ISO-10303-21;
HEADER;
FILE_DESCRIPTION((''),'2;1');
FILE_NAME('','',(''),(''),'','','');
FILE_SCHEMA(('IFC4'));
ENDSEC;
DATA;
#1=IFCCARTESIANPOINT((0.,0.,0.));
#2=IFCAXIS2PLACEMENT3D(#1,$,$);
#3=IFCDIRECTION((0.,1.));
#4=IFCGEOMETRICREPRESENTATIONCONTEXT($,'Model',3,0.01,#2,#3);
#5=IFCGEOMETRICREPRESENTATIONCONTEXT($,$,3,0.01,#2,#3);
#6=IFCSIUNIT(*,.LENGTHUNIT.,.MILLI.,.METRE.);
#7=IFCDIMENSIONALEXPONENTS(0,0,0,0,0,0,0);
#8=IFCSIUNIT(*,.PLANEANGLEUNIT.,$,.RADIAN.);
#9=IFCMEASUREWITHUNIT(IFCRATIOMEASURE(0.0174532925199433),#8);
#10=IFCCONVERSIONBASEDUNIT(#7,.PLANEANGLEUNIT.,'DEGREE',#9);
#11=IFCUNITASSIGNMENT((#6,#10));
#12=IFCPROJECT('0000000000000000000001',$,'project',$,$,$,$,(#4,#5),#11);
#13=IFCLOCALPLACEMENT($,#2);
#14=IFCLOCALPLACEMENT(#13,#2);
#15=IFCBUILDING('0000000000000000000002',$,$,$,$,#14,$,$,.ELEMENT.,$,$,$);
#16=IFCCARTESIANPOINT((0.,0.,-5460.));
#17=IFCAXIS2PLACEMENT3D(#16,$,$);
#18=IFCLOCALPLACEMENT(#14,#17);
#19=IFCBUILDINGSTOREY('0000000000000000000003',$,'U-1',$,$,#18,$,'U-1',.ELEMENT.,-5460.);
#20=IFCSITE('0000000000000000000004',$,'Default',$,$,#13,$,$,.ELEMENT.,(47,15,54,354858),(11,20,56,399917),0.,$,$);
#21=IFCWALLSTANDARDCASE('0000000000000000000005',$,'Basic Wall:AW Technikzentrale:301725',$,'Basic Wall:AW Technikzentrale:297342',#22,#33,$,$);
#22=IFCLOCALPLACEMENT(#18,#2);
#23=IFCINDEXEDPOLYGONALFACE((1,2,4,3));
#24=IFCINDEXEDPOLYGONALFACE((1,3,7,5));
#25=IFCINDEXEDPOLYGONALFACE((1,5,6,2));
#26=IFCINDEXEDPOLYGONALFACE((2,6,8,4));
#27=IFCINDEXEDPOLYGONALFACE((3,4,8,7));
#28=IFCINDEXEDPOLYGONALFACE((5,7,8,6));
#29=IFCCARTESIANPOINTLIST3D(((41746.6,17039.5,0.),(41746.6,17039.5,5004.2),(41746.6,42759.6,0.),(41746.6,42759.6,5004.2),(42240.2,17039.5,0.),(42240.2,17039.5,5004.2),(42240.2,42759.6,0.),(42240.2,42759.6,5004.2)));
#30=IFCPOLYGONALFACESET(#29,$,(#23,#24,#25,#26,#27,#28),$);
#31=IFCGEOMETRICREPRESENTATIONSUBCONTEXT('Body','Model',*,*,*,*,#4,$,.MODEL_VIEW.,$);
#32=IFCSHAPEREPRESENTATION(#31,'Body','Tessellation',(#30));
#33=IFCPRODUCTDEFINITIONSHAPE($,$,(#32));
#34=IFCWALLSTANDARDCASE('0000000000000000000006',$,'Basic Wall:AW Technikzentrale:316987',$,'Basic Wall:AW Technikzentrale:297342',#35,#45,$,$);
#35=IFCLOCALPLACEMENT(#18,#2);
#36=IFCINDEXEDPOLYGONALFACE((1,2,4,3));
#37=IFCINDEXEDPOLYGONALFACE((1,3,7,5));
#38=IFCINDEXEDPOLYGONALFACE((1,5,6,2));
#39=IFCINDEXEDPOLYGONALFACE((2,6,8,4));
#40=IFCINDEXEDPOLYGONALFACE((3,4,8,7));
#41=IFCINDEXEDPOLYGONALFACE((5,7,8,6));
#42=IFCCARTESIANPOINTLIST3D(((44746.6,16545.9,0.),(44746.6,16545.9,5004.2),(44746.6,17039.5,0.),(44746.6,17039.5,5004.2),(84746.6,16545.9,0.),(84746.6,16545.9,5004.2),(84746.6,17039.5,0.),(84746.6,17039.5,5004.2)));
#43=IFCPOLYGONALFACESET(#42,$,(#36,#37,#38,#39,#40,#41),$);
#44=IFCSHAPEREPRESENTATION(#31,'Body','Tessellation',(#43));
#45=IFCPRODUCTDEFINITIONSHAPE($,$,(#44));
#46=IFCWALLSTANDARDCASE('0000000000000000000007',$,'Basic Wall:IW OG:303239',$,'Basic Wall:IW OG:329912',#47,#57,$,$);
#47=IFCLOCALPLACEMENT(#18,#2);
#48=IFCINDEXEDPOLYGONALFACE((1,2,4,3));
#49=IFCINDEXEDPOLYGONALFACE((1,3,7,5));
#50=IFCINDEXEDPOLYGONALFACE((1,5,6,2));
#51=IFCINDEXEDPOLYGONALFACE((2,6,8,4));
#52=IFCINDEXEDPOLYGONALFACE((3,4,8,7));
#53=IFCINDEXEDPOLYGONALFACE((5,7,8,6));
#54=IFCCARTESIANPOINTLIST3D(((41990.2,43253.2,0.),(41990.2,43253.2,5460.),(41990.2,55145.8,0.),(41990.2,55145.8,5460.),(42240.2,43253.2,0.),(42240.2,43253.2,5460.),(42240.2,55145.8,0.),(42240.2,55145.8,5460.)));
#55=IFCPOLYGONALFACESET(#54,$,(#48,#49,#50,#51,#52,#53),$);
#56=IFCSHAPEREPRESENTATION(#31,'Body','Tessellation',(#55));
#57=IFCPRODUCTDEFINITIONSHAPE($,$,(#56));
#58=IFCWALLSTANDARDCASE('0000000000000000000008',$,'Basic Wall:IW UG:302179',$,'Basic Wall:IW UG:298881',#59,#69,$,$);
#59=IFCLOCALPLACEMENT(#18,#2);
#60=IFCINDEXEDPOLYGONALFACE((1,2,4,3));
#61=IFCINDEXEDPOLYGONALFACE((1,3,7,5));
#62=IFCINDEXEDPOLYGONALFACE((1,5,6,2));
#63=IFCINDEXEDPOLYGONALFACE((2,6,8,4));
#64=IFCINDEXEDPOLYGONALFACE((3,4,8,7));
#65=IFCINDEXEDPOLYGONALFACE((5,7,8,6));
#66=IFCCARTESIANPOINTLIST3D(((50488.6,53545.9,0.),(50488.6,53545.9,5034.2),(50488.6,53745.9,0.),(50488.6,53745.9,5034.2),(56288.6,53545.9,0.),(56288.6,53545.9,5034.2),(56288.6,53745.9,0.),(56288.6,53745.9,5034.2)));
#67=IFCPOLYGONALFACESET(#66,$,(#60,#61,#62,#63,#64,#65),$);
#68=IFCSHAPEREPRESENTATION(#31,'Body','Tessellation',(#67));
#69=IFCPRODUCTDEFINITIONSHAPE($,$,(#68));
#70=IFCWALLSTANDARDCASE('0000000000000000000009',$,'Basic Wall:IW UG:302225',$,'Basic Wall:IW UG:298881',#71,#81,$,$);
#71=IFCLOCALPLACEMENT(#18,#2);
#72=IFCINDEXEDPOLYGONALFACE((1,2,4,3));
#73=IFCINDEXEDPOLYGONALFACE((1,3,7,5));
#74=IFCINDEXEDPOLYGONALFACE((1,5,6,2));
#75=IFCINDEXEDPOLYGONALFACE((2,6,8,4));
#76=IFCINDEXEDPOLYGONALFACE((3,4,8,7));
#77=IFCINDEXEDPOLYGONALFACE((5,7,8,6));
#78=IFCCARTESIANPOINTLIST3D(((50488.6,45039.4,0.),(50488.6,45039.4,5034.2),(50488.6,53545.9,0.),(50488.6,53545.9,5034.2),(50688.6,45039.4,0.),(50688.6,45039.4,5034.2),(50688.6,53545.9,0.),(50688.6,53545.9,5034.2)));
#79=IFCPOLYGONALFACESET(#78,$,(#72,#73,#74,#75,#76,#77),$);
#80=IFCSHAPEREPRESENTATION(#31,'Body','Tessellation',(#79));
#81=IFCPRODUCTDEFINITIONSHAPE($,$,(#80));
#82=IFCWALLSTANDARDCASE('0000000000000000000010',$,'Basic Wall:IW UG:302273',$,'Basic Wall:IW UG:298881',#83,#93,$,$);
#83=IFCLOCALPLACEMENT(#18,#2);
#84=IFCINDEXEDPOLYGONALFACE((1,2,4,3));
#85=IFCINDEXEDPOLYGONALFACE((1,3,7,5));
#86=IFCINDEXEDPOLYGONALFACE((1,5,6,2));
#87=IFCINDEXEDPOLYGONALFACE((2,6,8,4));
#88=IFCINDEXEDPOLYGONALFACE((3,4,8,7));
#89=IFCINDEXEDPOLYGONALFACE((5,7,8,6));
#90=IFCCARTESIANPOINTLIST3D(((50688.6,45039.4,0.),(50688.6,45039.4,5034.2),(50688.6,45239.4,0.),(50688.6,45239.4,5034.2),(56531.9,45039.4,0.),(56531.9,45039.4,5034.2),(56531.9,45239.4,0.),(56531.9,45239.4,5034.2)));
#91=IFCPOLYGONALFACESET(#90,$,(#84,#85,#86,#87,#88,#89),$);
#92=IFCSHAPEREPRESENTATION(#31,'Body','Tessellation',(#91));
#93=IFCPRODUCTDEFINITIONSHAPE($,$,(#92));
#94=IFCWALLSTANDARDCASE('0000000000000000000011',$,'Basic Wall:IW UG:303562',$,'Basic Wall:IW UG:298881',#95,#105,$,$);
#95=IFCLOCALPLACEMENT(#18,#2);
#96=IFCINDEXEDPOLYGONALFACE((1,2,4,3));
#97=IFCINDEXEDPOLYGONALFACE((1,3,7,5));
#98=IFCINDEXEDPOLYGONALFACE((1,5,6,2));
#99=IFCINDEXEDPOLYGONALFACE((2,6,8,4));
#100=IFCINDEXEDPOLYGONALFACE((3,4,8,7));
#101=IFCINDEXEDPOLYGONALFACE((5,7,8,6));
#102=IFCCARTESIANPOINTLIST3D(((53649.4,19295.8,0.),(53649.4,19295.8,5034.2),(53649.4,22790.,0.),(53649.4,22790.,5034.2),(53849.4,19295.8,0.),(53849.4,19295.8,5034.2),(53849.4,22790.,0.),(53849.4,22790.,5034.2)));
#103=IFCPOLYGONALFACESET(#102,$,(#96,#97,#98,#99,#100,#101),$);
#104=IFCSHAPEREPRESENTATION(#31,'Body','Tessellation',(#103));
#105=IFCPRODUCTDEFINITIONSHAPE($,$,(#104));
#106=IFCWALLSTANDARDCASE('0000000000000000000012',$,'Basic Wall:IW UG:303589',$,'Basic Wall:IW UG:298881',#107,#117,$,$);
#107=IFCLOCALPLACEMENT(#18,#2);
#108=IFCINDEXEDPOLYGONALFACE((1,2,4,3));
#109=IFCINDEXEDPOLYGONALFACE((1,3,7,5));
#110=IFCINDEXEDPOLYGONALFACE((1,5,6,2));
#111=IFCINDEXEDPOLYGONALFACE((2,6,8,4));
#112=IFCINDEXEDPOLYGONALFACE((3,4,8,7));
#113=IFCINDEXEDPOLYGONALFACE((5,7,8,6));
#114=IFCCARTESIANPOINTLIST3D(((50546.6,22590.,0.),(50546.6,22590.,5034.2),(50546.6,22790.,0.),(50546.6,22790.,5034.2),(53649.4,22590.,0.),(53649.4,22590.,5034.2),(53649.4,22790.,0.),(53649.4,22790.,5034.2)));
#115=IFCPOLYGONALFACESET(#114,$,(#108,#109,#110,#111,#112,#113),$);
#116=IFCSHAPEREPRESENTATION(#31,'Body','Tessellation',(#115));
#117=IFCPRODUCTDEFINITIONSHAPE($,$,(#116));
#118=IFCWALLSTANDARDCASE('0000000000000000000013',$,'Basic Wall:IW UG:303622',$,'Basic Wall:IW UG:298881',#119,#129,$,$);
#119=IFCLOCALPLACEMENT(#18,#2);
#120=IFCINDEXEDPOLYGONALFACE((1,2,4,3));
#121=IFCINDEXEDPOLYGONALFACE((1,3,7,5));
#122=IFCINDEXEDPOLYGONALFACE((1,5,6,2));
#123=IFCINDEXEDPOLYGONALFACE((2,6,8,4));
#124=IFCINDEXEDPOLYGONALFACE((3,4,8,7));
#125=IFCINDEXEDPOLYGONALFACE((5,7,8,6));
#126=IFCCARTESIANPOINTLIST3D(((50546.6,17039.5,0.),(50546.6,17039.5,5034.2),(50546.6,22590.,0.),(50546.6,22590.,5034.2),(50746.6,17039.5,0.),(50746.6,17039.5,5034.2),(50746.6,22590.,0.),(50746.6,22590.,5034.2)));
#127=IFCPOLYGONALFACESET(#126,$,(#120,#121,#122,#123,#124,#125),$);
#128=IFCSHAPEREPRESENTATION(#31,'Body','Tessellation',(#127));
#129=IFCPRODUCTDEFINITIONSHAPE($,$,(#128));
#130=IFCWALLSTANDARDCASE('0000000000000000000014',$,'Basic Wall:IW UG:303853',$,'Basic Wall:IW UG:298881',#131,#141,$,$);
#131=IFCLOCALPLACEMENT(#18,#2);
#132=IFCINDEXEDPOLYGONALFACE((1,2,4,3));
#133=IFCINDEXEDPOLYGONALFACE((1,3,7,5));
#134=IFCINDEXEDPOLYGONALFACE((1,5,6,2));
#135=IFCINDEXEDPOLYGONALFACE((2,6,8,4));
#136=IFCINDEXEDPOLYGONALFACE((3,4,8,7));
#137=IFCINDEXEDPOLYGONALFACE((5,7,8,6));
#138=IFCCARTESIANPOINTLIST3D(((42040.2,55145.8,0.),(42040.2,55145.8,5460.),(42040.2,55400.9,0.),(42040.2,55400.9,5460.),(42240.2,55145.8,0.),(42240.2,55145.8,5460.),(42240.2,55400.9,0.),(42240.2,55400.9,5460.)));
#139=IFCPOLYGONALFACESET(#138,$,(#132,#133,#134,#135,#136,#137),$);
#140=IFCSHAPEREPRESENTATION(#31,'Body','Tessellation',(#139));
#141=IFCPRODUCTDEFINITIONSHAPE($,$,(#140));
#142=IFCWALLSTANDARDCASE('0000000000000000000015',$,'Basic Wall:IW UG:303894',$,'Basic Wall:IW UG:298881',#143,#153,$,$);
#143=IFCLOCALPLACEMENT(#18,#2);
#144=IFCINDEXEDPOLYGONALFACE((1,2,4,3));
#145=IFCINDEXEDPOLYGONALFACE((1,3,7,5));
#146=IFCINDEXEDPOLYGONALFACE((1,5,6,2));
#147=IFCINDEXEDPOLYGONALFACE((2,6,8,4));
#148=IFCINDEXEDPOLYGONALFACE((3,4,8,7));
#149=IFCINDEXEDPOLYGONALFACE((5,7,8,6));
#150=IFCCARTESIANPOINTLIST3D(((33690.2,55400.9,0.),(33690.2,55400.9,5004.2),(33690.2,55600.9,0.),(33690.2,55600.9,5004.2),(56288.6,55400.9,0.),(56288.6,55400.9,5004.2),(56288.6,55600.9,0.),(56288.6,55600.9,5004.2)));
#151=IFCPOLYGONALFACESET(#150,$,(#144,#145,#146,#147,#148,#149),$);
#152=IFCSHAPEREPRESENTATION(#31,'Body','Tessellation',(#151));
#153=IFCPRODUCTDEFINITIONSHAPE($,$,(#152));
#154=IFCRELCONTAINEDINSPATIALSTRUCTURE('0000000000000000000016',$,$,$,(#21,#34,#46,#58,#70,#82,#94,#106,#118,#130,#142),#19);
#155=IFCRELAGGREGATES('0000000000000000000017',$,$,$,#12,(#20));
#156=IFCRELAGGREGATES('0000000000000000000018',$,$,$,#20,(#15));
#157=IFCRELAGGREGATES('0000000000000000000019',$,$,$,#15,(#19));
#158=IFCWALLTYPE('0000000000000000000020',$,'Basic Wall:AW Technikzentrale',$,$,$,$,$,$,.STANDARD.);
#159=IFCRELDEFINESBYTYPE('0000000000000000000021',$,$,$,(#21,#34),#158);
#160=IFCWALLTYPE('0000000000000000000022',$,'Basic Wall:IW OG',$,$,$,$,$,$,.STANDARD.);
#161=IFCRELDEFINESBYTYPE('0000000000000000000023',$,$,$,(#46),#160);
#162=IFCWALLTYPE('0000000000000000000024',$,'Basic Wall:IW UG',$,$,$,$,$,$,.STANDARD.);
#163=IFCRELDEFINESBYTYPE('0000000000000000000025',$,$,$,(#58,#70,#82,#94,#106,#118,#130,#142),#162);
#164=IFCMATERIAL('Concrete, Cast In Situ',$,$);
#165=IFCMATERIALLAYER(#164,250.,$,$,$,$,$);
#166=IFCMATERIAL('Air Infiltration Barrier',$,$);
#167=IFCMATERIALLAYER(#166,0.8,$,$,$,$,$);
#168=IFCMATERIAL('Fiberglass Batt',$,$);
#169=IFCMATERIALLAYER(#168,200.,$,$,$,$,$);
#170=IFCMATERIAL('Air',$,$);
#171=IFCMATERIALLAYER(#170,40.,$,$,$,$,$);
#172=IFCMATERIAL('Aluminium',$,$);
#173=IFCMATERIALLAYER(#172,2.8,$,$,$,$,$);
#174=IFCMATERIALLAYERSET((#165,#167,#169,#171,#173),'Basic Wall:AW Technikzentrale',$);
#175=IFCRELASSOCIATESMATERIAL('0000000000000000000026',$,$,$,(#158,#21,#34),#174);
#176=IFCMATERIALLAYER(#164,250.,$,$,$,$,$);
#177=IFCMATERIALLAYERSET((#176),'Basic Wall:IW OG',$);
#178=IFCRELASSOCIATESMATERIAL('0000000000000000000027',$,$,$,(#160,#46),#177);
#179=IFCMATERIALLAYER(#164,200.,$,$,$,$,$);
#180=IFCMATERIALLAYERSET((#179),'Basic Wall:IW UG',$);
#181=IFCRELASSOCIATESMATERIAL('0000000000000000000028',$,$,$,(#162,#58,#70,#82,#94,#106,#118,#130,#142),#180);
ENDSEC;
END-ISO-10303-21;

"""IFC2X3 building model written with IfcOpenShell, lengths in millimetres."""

from ifc_helpers import new_model, entity, si_unit, converted_unit, direction, frame, frame_2d, origin, place, context, subcontext, project, spatial, polyline, rectangle, extrude, clip, bounded_halfspace, material, layer, layer_set, layer_usage, type_object, element, save


model = new_model("IFC2X3")

# Units and contexts
model_context = context("Model", 3, precision=0.01, world=origin(), true_north=direction((0.0, 1.0)))
context_of_model = context(None, 3, precision=0.01, world=origin(), true_north=direction((0.0, 1.0)))
body_context = subcontext(model_context, "Body", "Model", "MODEL_VIEW")
ifc_project = project(units=[si_unit("LENGTHUNIT", "METRE", prefix="MILLI"), converted_unit("PLANEANGLEUNIT", "DEGREE", entity("IfcRatioMeasure", 0.0174532925199433), si_unit("PLANEANGLEUNIT", "RADIAN"), dimensions=[0, 0, 0, 0, 0, 0, 0])], contexts=[model_context, context_of_model])

# Site, building, storey
site_placement = place(None, origin())
site = spatial("IfcSite", under=ifc_project, at=site_placement, Name="Default", CompositionType="ELEMENT", RefLatitude=(47, 15, 54, 354858), RefLongitude=(11, 20, 56, 399917), RefElevation=0.0)
building_placement = place(site_placement, origin())
building = spatial("IfcBuilding", under=site, at=building_placement, CompositionType="ELEMENT")
storey_placement = place(building_placement, frame((0.0, 0.0, -5460.0)))
storey = spatial("IfcBuildingStorey", under=building, at=storey_placement, Name="U-1", LongName="U-1", CompositionType="ELEMENT", Elevation=-5460.0)

# Shared definitions
ifc_material_1 = material(Name="Air Infiltration Barrier")
ifc_material_2 = material(Name="Fiberglass Batt")
ifc_material_3 = material(Name="Aluminium")

# Walls
ifc_material_4 = material(Name="Concrete, Cast In Situ")
ifc_layer_1 = layer(ifc_material_4, 250.0)
ifc_layer_2 = layer(ifc_material_1, 0.8)
ifc_layer_3 = layer(ifc_material_2, 200.0)
ifc_material_5 = material(Name="Air")
ifc_layer_4 = layer(ifc_material_5, 40.0)
ifc_layer_5 = layer(ifc_material_3, 2.8)
ifc_layer_set_1 = layer_set([ifc_layer_1, ifc_layer_2, ifc_layer_3, ifc_layer_4, ifc_layer_5], Name="Basic Wall:AW Technikzentrale")
wall_type_1 = type_object("IfcWallType", Name="Basic Wall:AW Technikzentrale", PredefinedType="STANDARD", material=ifc_layer_set_1)
ifc_layer_usage_1 = layer_usage(ifc_layer_set_1, "AXIS2", "NEGATIVE", 246.8)
wall_1_placement = place(storey_placement, frame((41993.4, 42759.6, 0.0), z_axis=(0.0, 0.0, 1.0), x_axis=(0.0, -1.0, 0.0)))
element("IfcWallStandardCase", 1, at=wall_1_placement, inside=storey, type_object=wall_type_1, material=ifc_layer_usage_1, Name="Basic Wall:AW Technikzentrale:301725", ObjectType="Basic Wall:AW Technikzentrale:297342", context=body_context, shape_type="Clipping", body=[
    clip(extrude(rectangle(XDim=25720.2, YDim=493.6, at=frame_2d((12860.1, 0.0), x_axis=(-1.0, 0.0))), origin(), (0.0, 0.0, 1.0), 5004.2), bounded_halfspace(frame((0.0, -246.8, 5004.2), z_axis=(0.0, 0.0, -1.0), x_axis=(1.0, 0.0, 0.0)), True, frame((0.0, -246.8, 5004.2)), polyline([(0.0, 0.0), (25720.2, 0.0), (25720.2, 493.6), (0.0, 493.6), (0.0, 0.0)]))),
])
ifc_layer_usage_2 = layer_usage(ifc_layer_set_1, "AXIS2", "NEGATIVE", 246.8)
wall_2_placement = place(storey_placement, frame((44746.6, 16792.7, 0.0)))
element("IfcWallStandardCase", 2, at=wall_2_placement, inside=storey, type_object=wall_type_1, material=ifc_layer_usage_2, Name="Basic Wall:AW Technikzentrale:316987", ObjectType="Basic Wall:AW Technikzentrale:297342", context=body_context, shape_type="Clipping", body=[
    clip(clip(extrude(rectangle(XDim=40000.0, YDim=493.6, at=frame_2d((20000.0, 0.0), x_axis=(-1.0, 0.0))), origin(), (0.0, 0.0, 1.0), 5004.2), bounded_halfspace(frame((39446.2, -246.8, 5004.2), z_axis=(0.0, 0.0, -1.0), x_axis=(0.0, 1.0, 0.0)), True, frame((39446.2, -246.8, 5004.2)), polyline([(0.0, 0.0), (553.8, 0.0), (553.8, 493.6), (0.0, 493.6), (0.0, 0.0)]))), bounded_halfspace(frame((0.0, -246.8, 5004.2), z_axis=(0.0, 0.0, -1.0), x_axis=(0.0, -1.0, 0.0)), True, frame((0.0, -246.8, 5004.2)), polyline([(0.0, 0.0), (553.8, 0.0), (553.8, 493.6), (0.0, 493.6), (0.0, 0.0)]))),
])
ifc_layer_6 = layer(ifc_material_4, 250.0)
ifc_layer_set_2 = layer_set([ifc_layer_6], Name="Basic Wall:IW OG")
ifc_layer_usage_3 = layer_usage(ifc_layer_set_2, "AXIS2", "NEGATIVE", 125.0)
wall_type_2 = type_object("IfcWallType", Name="Basic Wall:IW OG", PredefinedType="STANDARD", material=ifc_layer_set_2)
wall_3_placement = place(storey_placement, frame((42115.2, 55145.8, 0.0), z_axis=(0.0, 0.0, 1.0), x_axis=(0.0, -1.0, 0.0)))
element("IfcWallStandardCase", 3, at=wall_3_placement, inside=storey, type_object=wall_type_2, material=ifc_layer_usage_3, Name="Basic Wall:IW OG:303239", ObjectType="Basic Wall:IW OG:329912", context=body_context, shape_type="SweptSolid", body=[
    extrude(rectangle(XDim=11892.6, YDim=250.0, at=frame_2d((5946.3, 0.0), x_axis=(-1.0, 0.0))), origin(), (0.0, 0.0, 1.0), 5460.0),
])
ifc_layer_7 = layer(ifc_material_4, 200.0)
ifc_layer_set_3 = layer_set([ifc_layer_7], Name="Basic Wall:IW UG")
ifc_layer_usage_4 = layer_usage(ifc_layer_set_3, "AXIS2", "NEGATIVE", 100.0)
wall_type_3 = type_object("IfcWallType", Name="Basic Wall:IW UG", PredefinedType="STANDARD", material=ifc_layer_set_3)
wall_4_placement = place(storey_placement, frame((56288.6, 53645.9, 0.0), z_axis=(0.0, 0.0, 1.0), x_axis=(-1.0, 0.0, 0.0)))
element("IfcWallStandardCase", 4, at=wall_4_placement, inside=storey, type_object=wall_type_3, material=ifc_layer_usage_4, Name="Basic Wall:IW UG:302179", ObjectType="Basic Wall:IW UG:298881", context=body_context, shape_type="Clipping", body=[
    clip(extrude(rectangle(XDim=5800.0, YDim=200.0, at=frame_2d((2900.0, 0.0), x_axis=(-1.0, 0.0))), origin(), (0.0, 0.0, 1.0), 5034.2), bounded_halfspace(frame((0.0, -100.0, 5034.2), z_axis=(0.0, 0.0, -1.0), x_axis=(-1.0, 0.0, 0.0)), True, frame((0.0, -100.0, 5034.2)), polyline([(0.0, 0.0), (5800.0, 0.0), (5800.0, 200.0), (5600.0, 200.0), (0.0, 200.0), (0.0, 0.0)]))),
])
ifc_layer_usage_5 = layer_usage(ifc_layer_set_3, "AXIS2", "NEGATIVE", 100.0)
wall_5_placement = place(storey_placement, frame((50588.6, 53545.9, 0.0), z_axis=(0.0, 0.0, 1.0), x_axis=(0.0, -1.0, 0.0)))
element("IfcWallStandardCase", 5, at=wall_5_placement, inside=storey, type_object=wall_type_3, material=ifc_layer_usage_5, Name="Basic Wall:IW UG:302225", ObjectType="Basic Wall:IW UG:298881", context=body_context, shape_type="Clipping", body=[
    clip(extrude(rectangle(XDim=8506.4, YDim=200.0, at=frame_2d((4253.2, 0.0), x_axis=(-1.0, 0.0))), origin(), (0.0, 0.0, 1.0), 5034.2), bounded_halfspace(frame((0.0, -100.0, 5034.2), z_axis=(0.0, 0.0, -1.0), x_axis=(0.0, 1.0, 0.0)), True, frame((0.0, -100.0, 5034.2)), polyline([(0.0, 0.0), (8506.4, 0.0), (8506.4, 200.0), (8306.4, 200.0), (0.0, 200.0), (0.0, 0.0)]))),
])
ifc_layer_usage_6 = layer_usage(ifc_layer_set_3, "AXIS2", "NEGATIVE", 100.0)
wall_6_placement = place(storey_placement, frame((50688.6, 45139.4, 0.0)))
element("IfcWallStandardCase", 6, at=wall_6_placement, inside=storey, type_object=wall_type_3, material=ifc_layer_usage_6, Name="Basic Wall:IW UG:302273", ObjectType="Basic Wall:IW UG:298881", context=body_context, shape_type="Clipping", body=[
    clip(extrude(rectangle(XDim=5843.3, YDim=200.0, at=frame_2d((2921.7, 0.0), x_axis=(-1.0, 0.0))), origin(), (0.0, 0.0, 1.0), 5034.2), bounded_halfspace(frame((0.0, -100.0, 5034.2), z_axis=(0.0, 0.0, -1.0), x_axis=(1.0, 0.0, 0.0)), True, frame((0.0, -100.0, 5034.2)), polyline([(0.0, 0.0), (5643.3, 0.0), (5843.3, 0.0), (5843.3, 200.0), (0.0, 200.0), (0.0, 0.0)]))),
])
ifc_layer_usage_7 = layer_usage(ifc_layer_set_3, "AXIS2", "NEGATIVE", 100.0)
wall_7_placement = place(storey_placement, frame((53749.4, 19295.8, 0.0), z_axis=(0.0, 0.0, 1.0), x_axis=(0.0, 1.0, 0.0)))
element("IfcWallStandardCase", 7, at=wall_7_placement, inside=storey, type_object=wall_type_3, material=ifc_layer_usage_7, Name="Basic Wall:IW UG:303562", ObjectType="Basic Wall:IW UG:298881", context=body_context, shape_type="Clipping", body=[
    clip(extrude(rectangle(XDim=3494.1, YDim=200.0, at=frame_2d((1747.1, 0.0), x_axis=(-1.0, 0.0))), origin(), (0.0, 0.0, 1.0), 5034.2), bounded_halfspace(frame((0.0, -100.0, 5034.2), z_axis=(0.0, 0.0, -1.0), x_axis=(0.0, -1.0, 0.0)), True, frame((0.0, -100.0, 5034.2)), polyline([(0.0, 0.0), (3494.1, 0.0), (3494.1, 200.0), (3294.1, 200.0), (0.0, 200.0), (0.0, 0.0)]))),
])
ifc_layer_usage_8 = layer_usage(ifc_layer_set_3, "AXIS2", "NEGATIVE", 100.0)
wall_8_placement = place(storey_placement, frame((53649.4, 22690.0, 0.0), z_axis=(0.0, 0.0, 1.0), x_axis=(-1.0, 0.0, 0.0)))
element("IfcWallStandardCase", 8, at=wall_8_placement, inside=storey, type_object=wall_type_3, material=ifc_layer_usage_8, Name="Basic Wall:IW UG:303589", ObjectType="Basic Wall:IW UG:298881", context=body_context, shape_type="Clipping", body=[
    clip(extrude(rectangle(XDim=3102.8, YDim=200.0, at=frame_2d((1551.4, 0.0), x_axis=(-1.0, 0.0))), origin(), (0.0, 0.0, 1.0), 5034.2), bounded_halfspace(frame((0.0, -100.0, 5034.2), z_axis=(0.0, 0.0, -1.0), x_axis=(-1.0, 0.0, 0.0)), True, frame((0.0, -100.0, 5034.2)), polyline([(0.0, 0.0), (3102.8, 0.0), (3102.8, 200.0), (2902.8, 200.0), (0.0, 200.0), (0.0, 0.0)]))),
])
ifc_layer_usage_9 = layer_usage(ifc_layer_set_3, "AXIS2", "NEGATIVE", 100.0)
wall_9_placement = place(storey_placement, frame((50646.6, 22590.0, 0.0), z_axis=(0.0, 0.0, 1.0), x_axis=(0.0, -1.0, 0.0)))
element("IfcWallStandardCase", 9, at=wall_9_placement, inside=storey, type_object=wall_type_3, material=ifc_layer_usage_9, Name="Basic Wall:IW UG:303622", ObjectType="Basic Wall:IW UG:298881", context=body_context, shape_type="Clipping", body=[
    clip(extrude(rectangle(XDim=5550.5, YDim=200.0, at=frame_2d((2775.3, 0.0), x_axis=(-1.0, 0.0))), origin(), (0.0, 0.0, 1.0), 5034.2), bounded_halfspace(frame((0.0, -100.0, 5034.2), z_axis=(0.0, 0.0, -1.0), x_axis=(0.0, 1.0, 0.0)), True, frame((0.0, -100.0, 5034.2)), polyline([(0.0, 0.0), (5490.3, 0.0), (5490.3, 200.0), (0.0, 200.0), (0.0, 0.0)]))),
])
ifc_layer_usage_10 = layer_usage(ifc_layer_set_3, "AXIS2", "NEGATIVE", 100.0)
wall_10_placement = place(storey_placement, frame((42140.2, 55145.8, 0.0), z_axis=(0.0, 0.0, 1.0), x_axis=(0.0, 1.0, 0.0)))
element("IfcWallStandardCase", 10, at=wall_10_placement, inside=storey, type_object=wall_type_3, material=ifc_layer_usage_10, Name="Basic Wall:IW UG:303853", ObjectType="Basic Wall:IW UG:298881", context=body_context, shape_type="SweptSolid", body=[
    extrude(rectangle(XDim=255.0, YDim=200.0, at=frame_2d((127.5, 0.0), x_axis=(-1.0, 0.0))), origin(), (0.0, 0.0, 1.0), 5460.0),
])
ifc_layer_usage_11 = layer_usage(ifc_layer_set_3, "AXIS2", "NEGATIVE", 100.0)
wall_11_placement = place(storey_placement, frame((33690.2, 55500.9, 0.0)))
element("IfcWallStandardCase", 11, at=wall_11_placement, inside=storey, type_object=wall_type_3, material=ifc_layer_usage_11, Name="Basic Wall:IW UG:303894", ObjectType="Basic Wall:IW UG:298881", context=body_context, shape_type="Clipping", body=[
    clip(extrude(rectangle(XDim=22598.4, YDim=200.0, at=frame_2d((11299.2, 0.0), x_axis=(-1.0, 0.0))), origin(), (0.0, 0.0, 1.0), 5004.2), bounded_halfspace(frame((0.0, -100.0, 5004.2), z_axis=(0.0, 0.0, -1.0), x_axis=(0.0, -1.0, 0.0)), True, frame((0.0, -100.0, 5004.2)), polyline([(0.0, 0.0), (8056.4, 0.0), (8056.4, 200.0), (0.0, 200.0), (0.0, 0.0)]))),
])

save(model, "model.ifc")
